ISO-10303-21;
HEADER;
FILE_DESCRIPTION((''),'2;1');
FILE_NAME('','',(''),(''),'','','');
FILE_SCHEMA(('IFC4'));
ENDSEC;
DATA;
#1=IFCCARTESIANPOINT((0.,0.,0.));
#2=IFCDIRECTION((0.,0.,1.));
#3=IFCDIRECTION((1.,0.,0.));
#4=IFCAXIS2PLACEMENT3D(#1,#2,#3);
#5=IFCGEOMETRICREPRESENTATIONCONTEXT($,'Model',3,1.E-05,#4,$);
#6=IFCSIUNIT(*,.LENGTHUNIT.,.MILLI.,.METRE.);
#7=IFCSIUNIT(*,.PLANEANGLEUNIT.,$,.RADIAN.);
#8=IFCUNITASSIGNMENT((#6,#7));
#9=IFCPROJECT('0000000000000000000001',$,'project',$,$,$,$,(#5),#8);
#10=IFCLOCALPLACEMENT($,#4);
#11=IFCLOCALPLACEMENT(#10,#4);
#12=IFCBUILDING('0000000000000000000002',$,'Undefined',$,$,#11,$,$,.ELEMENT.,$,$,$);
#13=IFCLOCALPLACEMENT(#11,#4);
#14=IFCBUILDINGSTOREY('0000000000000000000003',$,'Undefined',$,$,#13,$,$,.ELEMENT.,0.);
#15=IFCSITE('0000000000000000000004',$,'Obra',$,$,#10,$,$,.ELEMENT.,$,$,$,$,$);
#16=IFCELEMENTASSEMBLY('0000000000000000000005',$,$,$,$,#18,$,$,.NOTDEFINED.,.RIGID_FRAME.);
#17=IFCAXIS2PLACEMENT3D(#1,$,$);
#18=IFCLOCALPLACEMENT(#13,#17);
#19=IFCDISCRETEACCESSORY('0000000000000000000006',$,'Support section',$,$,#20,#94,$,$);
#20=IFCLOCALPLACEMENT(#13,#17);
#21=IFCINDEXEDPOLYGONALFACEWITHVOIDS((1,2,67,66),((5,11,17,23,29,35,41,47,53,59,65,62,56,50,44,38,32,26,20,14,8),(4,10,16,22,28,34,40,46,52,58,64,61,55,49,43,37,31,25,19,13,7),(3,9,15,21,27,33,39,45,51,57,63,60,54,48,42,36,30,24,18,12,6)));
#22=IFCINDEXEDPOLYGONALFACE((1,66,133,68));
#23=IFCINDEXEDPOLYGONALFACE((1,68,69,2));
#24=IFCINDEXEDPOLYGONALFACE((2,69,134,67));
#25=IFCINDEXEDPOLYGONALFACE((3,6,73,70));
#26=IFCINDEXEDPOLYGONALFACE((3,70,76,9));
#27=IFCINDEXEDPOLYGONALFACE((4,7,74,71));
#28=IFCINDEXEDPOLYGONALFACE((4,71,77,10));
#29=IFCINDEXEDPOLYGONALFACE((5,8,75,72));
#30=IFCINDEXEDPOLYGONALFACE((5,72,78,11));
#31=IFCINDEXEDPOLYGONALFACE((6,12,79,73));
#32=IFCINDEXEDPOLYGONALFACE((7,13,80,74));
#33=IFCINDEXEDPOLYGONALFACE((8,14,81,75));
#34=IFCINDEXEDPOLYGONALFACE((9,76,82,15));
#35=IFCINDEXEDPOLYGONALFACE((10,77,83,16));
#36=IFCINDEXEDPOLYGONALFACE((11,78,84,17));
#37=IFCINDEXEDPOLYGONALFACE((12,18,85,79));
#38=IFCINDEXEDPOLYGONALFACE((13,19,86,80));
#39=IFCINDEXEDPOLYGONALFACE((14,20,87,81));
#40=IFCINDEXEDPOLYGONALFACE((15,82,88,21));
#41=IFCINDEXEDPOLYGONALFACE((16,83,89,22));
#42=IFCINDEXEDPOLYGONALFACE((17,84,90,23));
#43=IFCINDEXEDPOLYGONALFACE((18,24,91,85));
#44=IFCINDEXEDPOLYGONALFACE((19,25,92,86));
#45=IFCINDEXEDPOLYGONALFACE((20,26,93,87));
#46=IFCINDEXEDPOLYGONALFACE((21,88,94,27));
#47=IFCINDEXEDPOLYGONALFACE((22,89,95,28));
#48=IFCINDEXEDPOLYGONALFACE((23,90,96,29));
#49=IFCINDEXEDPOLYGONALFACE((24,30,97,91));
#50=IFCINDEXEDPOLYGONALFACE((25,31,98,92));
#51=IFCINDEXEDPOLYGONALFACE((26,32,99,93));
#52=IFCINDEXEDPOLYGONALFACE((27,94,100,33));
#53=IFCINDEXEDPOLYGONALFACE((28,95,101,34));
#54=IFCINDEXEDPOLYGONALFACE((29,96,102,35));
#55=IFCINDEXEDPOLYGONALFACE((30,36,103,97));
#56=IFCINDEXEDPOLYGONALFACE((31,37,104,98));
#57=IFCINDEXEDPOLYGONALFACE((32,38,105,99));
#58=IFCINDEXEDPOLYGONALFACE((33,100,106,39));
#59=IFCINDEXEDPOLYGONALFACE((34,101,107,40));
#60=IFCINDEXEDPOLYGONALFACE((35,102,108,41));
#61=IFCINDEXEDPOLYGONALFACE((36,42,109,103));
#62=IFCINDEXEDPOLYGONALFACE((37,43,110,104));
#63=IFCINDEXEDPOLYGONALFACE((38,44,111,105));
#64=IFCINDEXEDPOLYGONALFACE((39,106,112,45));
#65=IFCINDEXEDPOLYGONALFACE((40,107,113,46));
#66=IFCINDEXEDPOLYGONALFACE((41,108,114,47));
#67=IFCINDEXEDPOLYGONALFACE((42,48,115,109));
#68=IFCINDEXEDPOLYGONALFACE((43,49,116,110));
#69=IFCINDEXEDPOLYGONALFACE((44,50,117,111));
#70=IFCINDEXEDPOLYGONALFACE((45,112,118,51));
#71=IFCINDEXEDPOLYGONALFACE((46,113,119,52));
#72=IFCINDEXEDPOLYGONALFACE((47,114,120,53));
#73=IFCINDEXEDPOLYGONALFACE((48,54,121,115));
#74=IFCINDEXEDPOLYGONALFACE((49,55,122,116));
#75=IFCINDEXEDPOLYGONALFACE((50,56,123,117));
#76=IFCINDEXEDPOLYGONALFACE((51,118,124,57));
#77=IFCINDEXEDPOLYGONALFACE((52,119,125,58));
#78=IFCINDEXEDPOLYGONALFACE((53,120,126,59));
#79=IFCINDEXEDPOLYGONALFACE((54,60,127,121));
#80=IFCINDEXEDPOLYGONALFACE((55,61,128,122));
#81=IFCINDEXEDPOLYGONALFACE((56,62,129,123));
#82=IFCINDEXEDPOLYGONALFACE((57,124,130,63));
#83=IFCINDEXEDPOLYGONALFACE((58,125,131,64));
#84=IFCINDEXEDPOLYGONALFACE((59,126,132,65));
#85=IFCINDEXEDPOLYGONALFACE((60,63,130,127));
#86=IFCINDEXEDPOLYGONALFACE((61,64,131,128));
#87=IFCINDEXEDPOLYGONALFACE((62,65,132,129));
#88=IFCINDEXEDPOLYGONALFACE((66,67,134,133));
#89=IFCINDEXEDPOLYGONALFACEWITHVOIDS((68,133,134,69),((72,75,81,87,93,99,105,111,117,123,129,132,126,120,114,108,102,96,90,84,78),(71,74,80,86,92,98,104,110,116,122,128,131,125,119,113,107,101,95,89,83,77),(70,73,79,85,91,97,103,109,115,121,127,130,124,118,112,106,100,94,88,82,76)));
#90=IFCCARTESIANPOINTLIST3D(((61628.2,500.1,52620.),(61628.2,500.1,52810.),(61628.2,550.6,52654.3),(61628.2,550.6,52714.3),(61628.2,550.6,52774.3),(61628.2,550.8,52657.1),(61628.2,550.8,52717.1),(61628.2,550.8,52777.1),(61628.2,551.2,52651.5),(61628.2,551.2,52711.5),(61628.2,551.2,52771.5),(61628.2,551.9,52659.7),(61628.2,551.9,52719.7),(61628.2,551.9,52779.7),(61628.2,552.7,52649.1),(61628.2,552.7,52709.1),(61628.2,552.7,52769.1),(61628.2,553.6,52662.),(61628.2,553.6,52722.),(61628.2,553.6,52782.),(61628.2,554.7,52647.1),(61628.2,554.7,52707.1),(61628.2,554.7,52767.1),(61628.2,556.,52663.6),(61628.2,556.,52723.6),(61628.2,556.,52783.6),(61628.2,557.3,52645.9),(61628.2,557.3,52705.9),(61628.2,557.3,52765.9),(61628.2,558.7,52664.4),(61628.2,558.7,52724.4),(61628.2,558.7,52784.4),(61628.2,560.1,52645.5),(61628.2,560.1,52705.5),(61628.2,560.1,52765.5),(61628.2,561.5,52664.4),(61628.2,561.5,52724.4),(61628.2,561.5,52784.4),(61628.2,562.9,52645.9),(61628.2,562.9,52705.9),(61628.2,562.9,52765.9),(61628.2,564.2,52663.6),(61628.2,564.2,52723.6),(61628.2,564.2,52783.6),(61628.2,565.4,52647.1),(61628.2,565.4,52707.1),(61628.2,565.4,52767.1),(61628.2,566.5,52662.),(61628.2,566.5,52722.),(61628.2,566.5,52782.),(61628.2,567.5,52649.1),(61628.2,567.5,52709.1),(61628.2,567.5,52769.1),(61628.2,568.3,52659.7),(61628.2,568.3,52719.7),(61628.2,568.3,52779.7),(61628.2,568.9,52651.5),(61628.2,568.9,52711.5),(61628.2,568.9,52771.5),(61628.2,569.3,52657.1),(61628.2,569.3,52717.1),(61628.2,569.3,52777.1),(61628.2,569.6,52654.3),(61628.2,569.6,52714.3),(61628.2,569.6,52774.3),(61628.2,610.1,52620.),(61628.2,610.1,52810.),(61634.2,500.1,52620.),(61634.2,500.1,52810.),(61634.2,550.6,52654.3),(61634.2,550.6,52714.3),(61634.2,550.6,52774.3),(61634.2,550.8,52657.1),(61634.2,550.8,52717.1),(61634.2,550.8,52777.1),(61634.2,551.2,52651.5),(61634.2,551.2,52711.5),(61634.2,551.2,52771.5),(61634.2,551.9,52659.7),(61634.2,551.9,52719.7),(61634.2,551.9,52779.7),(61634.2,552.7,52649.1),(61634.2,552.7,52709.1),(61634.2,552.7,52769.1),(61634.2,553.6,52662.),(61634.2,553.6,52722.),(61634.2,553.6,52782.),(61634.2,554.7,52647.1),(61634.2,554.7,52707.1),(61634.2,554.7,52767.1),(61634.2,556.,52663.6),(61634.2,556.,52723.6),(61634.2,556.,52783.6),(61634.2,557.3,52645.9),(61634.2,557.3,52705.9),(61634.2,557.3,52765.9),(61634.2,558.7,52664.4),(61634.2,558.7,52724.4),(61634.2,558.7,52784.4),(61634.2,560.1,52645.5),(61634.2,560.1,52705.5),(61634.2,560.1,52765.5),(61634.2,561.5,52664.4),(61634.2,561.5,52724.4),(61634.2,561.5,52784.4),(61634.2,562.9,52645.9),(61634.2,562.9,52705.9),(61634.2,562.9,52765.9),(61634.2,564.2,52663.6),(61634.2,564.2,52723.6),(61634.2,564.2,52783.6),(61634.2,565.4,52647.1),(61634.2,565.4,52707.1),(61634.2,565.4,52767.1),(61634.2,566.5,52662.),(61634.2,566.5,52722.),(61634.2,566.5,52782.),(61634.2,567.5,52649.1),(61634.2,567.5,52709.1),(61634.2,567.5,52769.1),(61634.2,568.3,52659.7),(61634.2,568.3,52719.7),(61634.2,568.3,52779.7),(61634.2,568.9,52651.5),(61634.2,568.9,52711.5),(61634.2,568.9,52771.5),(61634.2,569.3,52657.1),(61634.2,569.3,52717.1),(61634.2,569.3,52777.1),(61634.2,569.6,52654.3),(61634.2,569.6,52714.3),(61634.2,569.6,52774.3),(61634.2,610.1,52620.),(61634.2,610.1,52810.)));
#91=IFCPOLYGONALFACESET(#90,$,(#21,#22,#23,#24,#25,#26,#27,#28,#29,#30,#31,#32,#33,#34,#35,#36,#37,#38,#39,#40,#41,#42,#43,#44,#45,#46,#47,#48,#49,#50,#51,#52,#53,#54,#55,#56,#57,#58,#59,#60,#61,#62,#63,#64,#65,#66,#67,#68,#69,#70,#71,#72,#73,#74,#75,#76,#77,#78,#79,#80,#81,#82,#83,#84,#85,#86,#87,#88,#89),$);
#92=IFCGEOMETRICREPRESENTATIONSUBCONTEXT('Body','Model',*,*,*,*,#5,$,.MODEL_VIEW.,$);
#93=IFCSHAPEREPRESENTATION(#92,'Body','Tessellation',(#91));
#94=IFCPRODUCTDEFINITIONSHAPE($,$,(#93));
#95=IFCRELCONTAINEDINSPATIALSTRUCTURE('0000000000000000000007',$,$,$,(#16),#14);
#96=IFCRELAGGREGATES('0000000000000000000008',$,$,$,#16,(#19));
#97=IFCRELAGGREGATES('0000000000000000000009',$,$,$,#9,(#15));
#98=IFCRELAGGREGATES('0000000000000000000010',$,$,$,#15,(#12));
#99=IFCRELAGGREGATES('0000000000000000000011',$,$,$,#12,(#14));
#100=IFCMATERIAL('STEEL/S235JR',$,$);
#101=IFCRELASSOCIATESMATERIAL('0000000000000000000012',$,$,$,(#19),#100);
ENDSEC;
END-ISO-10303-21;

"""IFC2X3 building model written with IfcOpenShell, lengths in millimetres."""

from ifc_helpers import new_model, si_unit, frame, origin_with_axes, origin_2d_with_axis, place, context, subcontext, project, spatial, rectangle, circle, extrude, source, transform, mapped, material, element, aggregate, save


model = new_model("IFC2X3")

# Units and contexts
model_context = context("Model", 3, precision=1e-05, world=origin_with_axes())
body_context = subcontext(model_context, "Body", "Model", "MODEL_VIEW")
ifc_project = project(units=[si_unit("LENGTHUNIT", "METRE", prefix="MILLI"), si_unit("PLANEANGLEUNIT", "RADIAN")], contexts=[model_context])

# Site, building, storey
site_placement = place(None, origin_with_axes())
site = spatial("IfcSite", under=ifc_project, at=site_placement, Name="Obra", CompositionType="ELEMENT")
building_placement = place(site_placement, origin_with_axes())
building = spatial("IfcBuilding", under=site, at=building_placement, Name="Undefined", CompositionType="ELEMENT")
storey_placement = place(building_placement, origin_with_axes())
storey = spatial("IfcBuildingStorey", under=building, at=storey_placement, Name="Undefined", CompositionType="ELEMENT", Elevation=0.0)

# Element assembly
ifc_material_1 = material(Name="STEEL/S235JR")
assembly_1_placement = place(storey_placement, origin_with_axes())
assembly_1 = element("IfcElementAssembly", 1, at=assembly_1_placement, inside=storey, AssemblyPlace="NOTDEFINED", PredefinedType="RIGID_FRAME")

# Discrete accessory, opening
shared_shape_1 = source(origin_with_axes(), body_context, "Body", "SweptSolid", [
    extrude(circle(Radius=9.5, at=origin_2d_with_axis()), frame((0.0, -9.2, 0.0), z_axis=(0.0, 1.0, 0.0), x_axis=(1.0, 0.0, 0.0)), (0.0, 0.0, 1.0), 6.2),
])
discrete_accessory_1_placement = place(assembly_1_placement, frame((61631.2, 555.1, 52620.0), z_axis=(0.0, 0.0, 1.0), x_axis=(0.000002, -1.0, 0.0)))
discrete_accessory_1 = element("IfcDiscreteAccessory", 2, at=discrete_accessory_1_placement, material=ifc_material_1, Name="Support section", context=body_context, shape_type="SweptSolid", body=[
    extrude(rectangle(XDim=6.0, YDim=110.0, at=origin_2d_with_axis()), frame((0.0, 0.0, 190.0), z_axis=(0.0, 0.0, -1.0), x_axis=(0.0, 1.0, 0.0)), (0.0, 0.0, 1.0), 190.0),
])
opening_1_placement = place(assembly_1_placement, frame((61625.1, 510.1, 52835.0), z_axis=(-0.000002, 1.0, 0.0), x_axis=(0.0, 0.0, -1.0)))
element("IfcOpeningElement", 3, at=opening_1_placement, cuts=discrete_accessory_1, ObjectType="Opening", context=body_context, shape_type="MappedRepresentation", body=[
    mapped(shared_shape_1, transform((60.0, 0.0, 50.0))),
    mapped(shared_shape_1, transform((120.0, 0.0, 50.0))),
    mapped(shared_shape_1, transform((180.0, 0.0, 50.0))),
])
aggregate(assembly_1, [discrete_accessory_1])

save(model, "model.ifc")
